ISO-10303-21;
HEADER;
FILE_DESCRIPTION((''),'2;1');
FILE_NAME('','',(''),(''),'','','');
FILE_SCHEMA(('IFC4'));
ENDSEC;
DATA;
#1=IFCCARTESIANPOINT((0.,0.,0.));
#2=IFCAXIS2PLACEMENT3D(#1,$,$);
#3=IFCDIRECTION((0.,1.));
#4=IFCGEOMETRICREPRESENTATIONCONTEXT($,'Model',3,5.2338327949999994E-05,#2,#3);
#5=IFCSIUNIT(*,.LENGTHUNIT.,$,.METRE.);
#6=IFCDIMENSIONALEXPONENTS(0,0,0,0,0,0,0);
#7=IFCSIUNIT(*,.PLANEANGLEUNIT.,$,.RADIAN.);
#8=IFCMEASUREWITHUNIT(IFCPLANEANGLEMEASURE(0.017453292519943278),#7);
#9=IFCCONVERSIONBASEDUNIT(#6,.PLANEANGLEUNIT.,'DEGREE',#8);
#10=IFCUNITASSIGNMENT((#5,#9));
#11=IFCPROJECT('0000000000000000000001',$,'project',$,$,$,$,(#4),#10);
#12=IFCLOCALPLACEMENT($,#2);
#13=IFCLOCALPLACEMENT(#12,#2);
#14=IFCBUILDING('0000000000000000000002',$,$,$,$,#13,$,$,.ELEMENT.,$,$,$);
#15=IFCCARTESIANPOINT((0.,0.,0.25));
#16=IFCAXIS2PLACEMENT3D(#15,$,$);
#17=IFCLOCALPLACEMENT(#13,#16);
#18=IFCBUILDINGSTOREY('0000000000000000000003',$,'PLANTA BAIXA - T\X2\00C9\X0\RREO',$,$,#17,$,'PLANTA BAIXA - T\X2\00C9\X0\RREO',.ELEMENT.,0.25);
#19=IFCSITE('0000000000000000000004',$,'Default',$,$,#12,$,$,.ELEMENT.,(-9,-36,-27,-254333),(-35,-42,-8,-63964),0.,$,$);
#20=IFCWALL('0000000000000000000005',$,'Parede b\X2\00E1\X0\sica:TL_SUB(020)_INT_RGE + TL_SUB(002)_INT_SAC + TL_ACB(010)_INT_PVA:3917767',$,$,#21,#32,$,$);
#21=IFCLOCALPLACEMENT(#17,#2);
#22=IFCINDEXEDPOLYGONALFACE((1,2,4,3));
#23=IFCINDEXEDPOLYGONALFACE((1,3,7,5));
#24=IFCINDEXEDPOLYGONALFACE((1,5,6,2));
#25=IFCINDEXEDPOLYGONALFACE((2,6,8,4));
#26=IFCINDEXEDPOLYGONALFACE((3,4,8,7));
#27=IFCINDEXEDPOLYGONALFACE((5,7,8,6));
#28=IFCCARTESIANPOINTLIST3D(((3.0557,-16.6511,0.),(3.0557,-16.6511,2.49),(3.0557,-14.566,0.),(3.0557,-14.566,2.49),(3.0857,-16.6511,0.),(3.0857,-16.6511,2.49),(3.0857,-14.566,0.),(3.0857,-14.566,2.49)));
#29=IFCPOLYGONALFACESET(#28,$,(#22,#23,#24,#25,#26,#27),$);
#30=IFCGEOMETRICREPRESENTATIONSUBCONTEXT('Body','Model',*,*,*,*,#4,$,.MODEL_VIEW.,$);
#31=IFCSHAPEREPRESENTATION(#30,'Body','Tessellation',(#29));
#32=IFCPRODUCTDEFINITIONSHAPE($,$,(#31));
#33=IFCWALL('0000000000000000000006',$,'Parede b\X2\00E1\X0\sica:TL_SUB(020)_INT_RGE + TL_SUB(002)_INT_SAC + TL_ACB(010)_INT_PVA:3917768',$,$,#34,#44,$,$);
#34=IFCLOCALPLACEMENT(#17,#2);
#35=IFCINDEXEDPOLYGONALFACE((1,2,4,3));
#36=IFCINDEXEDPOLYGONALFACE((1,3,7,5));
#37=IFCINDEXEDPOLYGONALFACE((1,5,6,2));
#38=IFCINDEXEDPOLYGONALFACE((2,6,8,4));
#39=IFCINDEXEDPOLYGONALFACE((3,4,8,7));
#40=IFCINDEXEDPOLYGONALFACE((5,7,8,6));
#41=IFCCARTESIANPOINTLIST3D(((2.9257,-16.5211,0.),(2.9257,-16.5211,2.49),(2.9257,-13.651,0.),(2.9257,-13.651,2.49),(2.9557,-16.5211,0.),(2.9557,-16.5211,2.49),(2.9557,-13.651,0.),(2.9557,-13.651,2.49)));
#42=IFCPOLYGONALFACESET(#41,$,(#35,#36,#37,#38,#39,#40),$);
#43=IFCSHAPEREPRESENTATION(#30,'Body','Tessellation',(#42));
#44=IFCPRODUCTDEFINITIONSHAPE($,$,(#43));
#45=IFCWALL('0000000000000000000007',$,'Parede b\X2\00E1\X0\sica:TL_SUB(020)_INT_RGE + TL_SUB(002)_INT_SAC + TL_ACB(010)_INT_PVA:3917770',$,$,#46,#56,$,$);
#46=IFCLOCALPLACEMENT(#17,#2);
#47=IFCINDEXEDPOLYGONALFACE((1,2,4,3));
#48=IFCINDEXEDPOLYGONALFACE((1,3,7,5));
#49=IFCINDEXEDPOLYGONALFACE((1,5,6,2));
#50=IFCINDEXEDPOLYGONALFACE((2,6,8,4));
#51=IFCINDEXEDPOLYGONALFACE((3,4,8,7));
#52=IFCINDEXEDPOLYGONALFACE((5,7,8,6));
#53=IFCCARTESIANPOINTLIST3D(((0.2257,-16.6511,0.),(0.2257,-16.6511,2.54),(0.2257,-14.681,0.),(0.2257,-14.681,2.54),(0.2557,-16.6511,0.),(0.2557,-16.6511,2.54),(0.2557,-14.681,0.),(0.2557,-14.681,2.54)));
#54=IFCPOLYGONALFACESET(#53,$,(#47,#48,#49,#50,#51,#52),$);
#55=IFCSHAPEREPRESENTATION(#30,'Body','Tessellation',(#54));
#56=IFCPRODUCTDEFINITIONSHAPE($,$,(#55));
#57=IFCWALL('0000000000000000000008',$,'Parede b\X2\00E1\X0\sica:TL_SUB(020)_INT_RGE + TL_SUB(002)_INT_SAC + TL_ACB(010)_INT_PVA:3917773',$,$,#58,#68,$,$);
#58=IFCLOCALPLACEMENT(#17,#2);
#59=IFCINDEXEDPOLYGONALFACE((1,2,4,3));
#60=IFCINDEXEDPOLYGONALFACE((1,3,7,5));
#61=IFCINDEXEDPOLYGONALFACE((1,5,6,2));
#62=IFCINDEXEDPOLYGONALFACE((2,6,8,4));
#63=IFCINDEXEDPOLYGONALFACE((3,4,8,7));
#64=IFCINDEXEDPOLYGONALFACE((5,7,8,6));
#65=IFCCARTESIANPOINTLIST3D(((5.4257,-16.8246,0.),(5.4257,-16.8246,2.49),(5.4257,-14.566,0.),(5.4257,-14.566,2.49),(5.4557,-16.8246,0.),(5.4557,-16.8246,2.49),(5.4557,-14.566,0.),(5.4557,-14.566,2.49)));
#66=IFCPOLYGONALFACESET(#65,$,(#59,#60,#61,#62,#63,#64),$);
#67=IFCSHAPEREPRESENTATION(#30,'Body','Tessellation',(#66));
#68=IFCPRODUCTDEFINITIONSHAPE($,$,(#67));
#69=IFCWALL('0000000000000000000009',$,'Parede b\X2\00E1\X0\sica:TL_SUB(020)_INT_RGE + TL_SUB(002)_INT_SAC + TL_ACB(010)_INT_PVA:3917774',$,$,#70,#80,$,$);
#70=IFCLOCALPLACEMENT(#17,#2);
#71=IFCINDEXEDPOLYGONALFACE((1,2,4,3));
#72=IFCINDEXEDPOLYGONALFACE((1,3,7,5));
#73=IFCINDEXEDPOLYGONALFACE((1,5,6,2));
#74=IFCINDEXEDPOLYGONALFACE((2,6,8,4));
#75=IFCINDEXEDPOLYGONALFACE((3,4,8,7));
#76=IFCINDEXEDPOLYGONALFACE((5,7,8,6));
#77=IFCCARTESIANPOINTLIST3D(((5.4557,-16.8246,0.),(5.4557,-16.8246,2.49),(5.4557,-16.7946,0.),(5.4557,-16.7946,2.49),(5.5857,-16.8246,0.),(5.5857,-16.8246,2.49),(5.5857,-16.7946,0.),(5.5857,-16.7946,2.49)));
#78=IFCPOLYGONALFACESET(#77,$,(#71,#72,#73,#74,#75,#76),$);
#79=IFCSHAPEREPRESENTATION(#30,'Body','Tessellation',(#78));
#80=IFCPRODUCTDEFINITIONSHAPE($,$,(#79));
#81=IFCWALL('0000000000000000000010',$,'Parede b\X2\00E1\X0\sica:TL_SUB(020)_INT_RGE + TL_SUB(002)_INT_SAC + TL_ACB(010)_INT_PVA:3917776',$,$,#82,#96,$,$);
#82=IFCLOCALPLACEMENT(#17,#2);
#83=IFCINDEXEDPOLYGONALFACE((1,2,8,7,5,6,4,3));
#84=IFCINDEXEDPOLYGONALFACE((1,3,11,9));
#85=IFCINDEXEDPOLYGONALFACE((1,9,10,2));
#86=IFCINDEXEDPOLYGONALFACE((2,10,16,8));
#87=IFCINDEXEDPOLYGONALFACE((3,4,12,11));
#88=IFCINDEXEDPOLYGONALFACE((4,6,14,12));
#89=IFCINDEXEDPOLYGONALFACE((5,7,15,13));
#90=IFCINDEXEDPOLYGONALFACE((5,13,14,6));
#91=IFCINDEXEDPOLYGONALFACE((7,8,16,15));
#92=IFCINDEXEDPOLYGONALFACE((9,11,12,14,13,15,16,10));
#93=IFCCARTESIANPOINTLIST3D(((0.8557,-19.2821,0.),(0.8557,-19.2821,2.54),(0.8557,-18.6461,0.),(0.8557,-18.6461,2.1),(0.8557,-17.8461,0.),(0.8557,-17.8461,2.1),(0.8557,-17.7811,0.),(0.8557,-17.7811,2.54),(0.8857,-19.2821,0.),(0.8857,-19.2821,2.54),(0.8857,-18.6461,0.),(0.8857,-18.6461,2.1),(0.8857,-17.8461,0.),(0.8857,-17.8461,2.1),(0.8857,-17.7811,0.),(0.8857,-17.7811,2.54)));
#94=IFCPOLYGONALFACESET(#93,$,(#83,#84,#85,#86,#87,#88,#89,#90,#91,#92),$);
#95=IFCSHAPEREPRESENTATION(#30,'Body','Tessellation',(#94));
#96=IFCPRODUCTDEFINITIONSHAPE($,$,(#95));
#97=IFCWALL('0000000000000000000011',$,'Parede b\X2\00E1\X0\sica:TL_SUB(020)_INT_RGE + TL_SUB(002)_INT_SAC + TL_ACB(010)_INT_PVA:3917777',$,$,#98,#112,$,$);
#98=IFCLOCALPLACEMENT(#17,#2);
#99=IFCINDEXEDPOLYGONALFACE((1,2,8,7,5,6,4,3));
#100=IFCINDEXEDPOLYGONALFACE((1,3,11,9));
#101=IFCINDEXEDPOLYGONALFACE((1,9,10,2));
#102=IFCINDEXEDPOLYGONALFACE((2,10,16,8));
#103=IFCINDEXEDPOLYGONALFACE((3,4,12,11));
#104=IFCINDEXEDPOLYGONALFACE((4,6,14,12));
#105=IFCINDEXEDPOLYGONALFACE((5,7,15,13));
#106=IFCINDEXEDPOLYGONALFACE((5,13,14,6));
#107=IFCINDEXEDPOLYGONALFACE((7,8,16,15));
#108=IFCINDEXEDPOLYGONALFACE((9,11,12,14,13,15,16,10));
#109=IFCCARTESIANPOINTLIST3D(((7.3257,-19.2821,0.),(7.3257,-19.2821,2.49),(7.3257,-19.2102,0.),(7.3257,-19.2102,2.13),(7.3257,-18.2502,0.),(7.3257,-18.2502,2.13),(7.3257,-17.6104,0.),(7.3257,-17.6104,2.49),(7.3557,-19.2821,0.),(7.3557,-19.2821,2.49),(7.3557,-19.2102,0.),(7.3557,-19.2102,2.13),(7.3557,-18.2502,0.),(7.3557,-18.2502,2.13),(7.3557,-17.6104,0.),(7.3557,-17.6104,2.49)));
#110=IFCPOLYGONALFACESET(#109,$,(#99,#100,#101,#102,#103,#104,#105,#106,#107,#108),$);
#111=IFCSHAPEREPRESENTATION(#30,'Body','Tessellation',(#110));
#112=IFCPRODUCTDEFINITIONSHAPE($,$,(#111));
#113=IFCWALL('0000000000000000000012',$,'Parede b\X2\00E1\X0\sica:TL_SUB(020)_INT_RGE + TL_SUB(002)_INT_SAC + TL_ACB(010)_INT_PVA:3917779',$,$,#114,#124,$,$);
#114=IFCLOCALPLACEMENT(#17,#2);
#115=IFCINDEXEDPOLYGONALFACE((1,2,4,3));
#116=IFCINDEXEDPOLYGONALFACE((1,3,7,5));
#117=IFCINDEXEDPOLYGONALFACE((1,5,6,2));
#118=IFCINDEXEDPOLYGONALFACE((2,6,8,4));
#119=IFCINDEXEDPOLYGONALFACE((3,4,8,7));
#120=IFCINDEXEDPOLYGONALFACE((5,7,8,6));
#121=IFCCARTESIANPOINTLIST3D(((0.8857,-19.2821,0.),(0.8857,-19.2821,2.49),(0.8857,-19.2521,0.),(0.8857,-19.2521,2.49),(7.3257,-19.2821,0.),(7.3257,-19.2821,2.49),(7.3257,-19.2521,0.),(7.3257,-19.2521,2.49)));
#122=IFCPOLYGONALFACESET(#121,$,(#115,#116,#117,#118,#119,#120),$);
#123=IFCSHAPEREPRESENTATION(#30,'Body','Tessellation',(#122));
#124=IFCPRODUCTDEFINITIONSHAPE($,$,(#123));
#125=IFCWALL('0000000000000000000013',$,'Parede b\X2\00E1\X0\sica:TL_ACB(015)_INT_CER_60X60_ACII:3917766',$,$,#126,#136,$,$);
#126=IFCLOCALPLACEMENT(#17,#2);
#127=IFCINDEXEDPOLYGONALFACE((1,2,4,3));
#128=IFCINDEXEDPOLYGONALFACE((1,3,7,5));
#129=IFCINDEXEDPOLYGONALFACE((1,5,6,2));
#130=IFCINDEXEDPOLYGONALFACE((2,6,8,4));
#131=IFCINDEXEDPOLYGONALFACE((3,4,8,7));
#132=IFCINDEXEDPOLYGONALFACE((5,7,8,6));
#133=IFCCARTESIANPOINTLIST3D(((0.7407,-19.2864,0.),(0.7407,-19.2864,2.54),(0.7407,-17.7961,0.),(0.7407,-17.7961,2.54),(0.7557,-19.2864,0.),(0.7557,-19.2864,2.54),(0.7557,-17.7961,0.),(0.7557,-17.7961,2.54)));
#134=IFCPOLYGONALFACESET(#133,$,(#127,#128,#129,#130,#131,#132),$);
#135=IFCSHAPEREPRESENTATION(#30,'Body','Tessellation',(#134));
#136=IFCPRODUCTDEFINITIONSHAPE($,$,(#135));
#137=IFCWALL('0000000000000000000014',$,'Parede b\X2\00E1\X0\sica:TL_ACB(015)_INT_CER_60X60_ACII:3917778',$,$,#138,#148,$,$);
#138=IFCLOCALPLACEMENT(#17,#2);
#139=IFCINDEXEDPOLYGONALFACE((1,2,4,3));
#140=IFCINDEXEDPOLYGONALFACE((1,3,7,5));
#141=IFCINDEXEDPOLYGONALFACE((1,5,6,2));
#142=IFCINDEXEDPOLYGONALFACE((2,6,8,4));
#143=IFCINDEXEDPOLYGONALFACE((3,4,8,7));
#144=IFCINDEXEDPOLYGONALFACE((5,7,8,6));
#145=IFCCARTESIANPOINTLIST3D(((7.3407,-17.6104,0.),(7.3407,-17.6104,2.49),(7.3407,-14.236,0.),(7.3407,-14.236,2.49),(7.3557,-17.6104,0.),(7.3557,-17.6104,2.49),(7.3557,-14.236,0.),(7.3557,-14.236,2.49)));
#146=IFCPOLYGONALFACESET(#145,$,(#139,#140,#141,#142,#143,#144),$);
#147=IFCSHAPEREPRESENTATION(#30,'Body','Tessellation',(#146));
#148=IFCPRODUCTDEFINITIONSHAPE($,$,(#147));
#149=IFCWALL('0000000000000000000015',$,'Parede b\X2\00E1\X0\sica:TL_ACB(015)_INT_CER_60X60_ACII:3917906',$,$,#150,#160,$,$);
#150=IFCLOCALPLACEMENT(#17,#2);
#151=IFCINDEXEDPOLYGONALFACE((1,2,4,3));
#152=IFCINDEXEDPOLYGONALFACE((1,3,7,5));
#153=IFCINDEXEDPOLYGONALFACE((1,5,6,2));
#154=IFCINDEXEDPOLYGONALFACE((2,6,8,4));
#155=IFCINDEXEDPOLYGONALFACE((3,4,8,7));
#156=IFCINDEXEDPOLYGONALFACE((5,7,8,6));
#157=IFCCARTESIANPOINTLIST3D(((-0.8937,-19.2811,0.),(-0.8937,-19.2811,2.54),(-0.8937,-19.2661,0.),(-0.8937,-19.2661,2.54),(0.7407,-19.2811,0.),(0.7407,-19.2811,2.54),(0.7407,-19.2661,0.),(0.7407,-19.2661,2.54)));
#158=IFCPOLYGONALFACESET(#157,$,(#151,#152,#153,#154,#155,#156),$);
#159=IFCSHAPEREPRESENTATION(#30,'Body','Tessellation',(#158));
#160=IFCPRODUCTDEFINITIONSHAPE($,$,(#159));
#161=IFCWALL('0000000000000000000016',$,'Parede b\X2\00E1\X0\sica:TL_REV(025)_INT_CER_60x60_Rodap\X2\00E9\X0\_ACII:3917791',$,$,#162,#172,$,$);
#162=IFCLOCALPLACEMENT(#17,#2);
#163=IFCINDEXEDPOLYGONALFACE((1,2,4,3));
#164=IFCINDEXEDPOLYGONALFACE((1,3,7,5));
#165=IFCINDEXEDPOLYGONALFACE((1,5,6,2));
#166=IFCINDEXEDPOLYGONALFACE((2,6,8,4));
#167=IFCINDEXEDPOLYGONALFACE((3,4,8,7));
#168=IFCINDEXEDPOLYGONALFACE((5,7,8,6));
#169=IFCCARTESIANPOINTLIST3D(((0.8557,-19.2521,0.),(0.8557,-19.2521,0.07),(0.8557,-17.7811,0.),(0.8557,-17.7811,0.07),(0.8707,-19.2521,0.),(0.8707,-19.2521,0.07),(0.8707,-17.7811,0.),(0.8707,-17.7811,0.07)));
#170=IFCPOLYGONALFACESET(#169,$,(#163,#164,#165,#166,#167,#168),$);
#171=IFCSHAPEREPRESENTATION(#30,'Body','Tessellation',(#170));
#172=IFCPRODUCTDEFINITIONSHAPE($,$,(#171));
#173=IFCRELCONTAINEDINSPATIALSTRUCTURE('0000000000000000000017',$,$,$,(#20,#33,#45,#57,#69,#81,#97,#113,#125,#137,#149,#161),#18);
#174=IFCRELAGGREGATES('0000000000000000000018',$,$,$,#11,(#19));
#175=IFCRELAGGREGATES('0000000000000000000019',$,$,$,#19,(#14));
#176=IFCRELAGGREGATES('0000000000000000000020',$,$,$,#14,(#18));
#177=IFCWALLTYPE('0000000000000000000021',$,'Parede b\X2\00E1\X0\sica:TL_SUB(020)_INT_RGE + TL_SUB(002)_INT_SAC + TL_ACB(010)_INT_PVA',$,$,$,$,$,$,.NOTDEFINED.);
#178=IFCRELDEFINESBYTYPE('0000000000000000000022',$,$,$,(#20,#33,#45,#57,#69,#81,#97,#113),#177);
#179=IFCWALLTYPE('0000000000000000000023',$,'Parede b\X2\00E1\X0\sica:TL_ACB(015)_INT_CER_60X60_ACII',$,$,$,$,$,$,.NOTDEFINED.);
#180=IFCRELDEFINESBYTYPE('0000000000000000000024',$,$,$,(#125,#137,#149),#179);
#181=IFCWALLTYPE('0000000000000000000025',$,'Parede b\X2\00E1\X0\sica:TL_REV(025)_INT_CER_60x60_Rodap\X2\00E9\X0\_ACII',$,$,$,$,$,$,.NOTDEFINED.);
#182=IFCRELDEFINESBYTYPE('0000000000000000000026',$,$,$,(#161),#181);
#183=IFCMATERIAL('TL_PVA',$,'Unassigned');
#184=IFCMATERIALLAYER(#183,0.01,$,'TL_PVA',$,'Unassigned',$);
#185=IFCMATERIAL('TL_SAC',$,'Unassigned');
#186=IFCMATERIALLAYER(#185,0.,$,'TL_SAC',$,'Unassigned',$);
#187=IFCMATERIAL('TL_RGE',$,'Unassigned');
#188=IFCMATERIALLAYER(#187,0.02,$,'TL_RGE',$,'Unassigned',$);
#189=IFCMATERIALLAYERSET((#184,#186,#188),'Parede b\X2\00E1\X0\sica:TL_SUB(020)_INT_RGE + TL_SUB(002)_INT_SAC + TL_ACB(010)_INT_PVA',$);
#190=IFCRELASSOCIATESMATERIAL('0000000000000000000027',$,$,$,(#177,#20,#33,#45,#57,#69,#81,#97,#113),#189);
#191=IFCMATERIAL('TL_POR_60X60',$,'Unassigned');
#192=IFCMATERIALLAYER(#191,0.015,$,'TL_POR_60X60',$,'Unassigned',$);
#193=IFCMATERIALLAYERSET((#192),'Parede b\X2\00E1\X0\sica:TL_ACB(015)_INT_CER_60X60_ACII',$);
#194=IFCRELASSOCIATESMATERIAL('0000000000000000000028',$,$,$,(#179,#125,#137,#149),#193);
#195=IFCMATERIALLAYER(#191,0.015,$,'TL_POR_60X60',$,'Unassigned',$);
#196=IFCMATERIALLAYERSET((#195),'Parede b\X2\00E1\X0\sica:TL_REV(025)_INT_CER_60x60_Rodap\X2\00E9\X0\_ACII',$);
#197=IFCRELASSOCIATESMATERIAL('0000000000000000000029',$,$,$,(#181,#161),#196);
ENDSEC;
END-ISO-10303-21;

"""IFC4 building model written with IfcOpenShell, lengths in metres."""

from ifc_helpers import new_model, entity, si_unit, converted_unit, direction, frame, frame_2d, origin, place, context, subcontext, project, spatial, rectangle, extrude, material, layer, layer_set, layer_usage, type_object, element, save


model = new_model("IFC4")

# Units and contexts
model_context = context("Model", 3, precision=5.2338327949999994e-05, world=origin(), true_north=direction((0.0, 1.0)))
body_context = subcontext(model_context, "Body", "Model", "MODEL_VIEW")
ifc_project = project(units=[si_unit("LENGTHUNIT", "METRE"), converted_unit("PLANEANGLEUNIT", "DEGREE", entity("IfcPlaneAngleMeasure", 0.017453292519943278), si_unit("PLANEANGLEUNIT", "RADIAN"), dimensions=[0, 0, 0, 0, 0, 0, 0])], contexts=[model_context])

# Site, building, storey
site_placement = place(None, frame((0.0, 0.0, 0.0)))
site = spatial("IfcSite", under=ifc_project, at=site_placement, Name="Default", CompositionType="ELEMENT", RefLatitude=(-9, -36, -27, -254333), RefLongitude=(-35, -42, -8, -63964), RefElevation=0.0)
building_placement = place(site_placement, origin())
building = spatial("IfcBuilding", under=site, at=building_placement, CompositionType="ELEMENT")
storey_placement = place(building_placement, frame((0.0, 0.0, 0.25)))
storey = spatial("IfcBuildingStorey", under=building, at=storey_placement, Name="PLANTA BAIXA - TÉRREO", LongName="PLANTA BAIXA - TÉRREO", CompositionType="ELEMENT", Elevation=0.25)

# Shared definitions
ifc_material_1 = material(Name="TL_PVA", Category="Unassigned")
ifc_layer_1 = layer(ifc_material_1, 0.01, Name="TL_PVA", Category="Unassigned")
ifc_material_2 = material(Name="TL_SAC", Category="Unassigned")
ifc_layer_2 = layer(ifc_material_2, 0.0, Name="TL_SAC", Category="Unassigned")
ifc_material_3 = material(Name="TL_RGE", Category="Unassigned")
ifc_layer_3 = layer(ifc_material_3, 0.02, Name="TL_RGE", Category="Unassigned")
ifc_layer_set_1 = layer_set([ifc_layer_1, ifc_layer_2, ifc_layer_3], Name="Parede básica:TL_SUB(020)_INT_RGE + TL_SUB(002)_INT_SAC + TL_ACB(010)_INT_PVA")
wall_type_1 = type_object("IfcWallType", Name="Parede básica:TL_SUB(020)_INT_RGE + TL_SUB(002)_INT_SAC + TL_ACB(010)_INT_PVA", PredefinedType="NOTDEFINED", material=ifc_layer_set_1)

# Walls
ifc_layer_usage_1 = layer_usage(ifc_layer_set_1, "AXIS2", "NEGATIVE", 0.015)
wall_1_placement = place(storey_placement, frame((3.0707, -14.566, 0.0), z_axis=(0.0, 0.0, 1.0), x_axis=(0.0, -1.0, 0.0)))
element("IfcWall", 1, at=wall_1_placement, inside=storey, type_object=wall_type_1, material=ifc_layer_usage_1, Name="Parede básica:TL_SUB(020)_INT_RGE + TL_SUB(002)_INT_SAC + TL_ACB(010)_INT_PVA:3917767", context=body_context, shape_type="SweptSolid", body=[
    extrude(rectangle(XDim=2.0851, YDim=0.03, at=frame_2d((1.0426, 0.0), x_axis=(-1.0, 0.0))), origin(), (0.0, 0.0, 1.0), 2.49),
])
ifc_layer_usage_2 = layer_usage(ifc_layer_set_1, "AXIS2", "NEGATIVE", 0.015)
wall_2_placement = place(storey_placement, frame((2.9407, -16.5211, 0.0), z_axis=(0.0, 0.0, 1.0), x_axis=(0.0, 1.0, 0.0)))
element("IfcWall", 2, at=wall_2_placement, inside=storey, type_object=wall_type_1, material=ifc_layer_usage_2, Name="Parede básica:TL_SUB(020)_INT_RGE + TL_SUB(002)_INT_SAC + TL_ACB(010)_INT_PVA:3917768", context=body_context, shape_type="SweptSolid", body=[
    extrude(rectangle(XDim=2.8701, YDim=0.03, at=frame_2d((1.4351, 0.0), x_axis=(-1.0, 0.0))), origin(), (0.0, 0.0, 1.0), 2.49),
])
ifc_layer_usage_3 = layer_usage(ifc_layer_set_1, "AXIS2", "NEGATIVE", 0.015)
wall_3_placement = place(storey_placement, frame((0.2407, -16.6511, 0.0), z_axis=(0.0, 0.0, 1.0), x_axis=(0.0, 1.0, 0.0)))
element("IfcWall", 3, at=wall_3_placement, inside=storey, type_object=wall_type_1, material=ifc_layer_usage_3, Name="Parede básica:TL_SUB(020)_INT_RGE + TL_SUB(002)_INT_SAC + TL_ACB(010)_INT_PVA:3917770", context=body_context, shape_type="SweptSolid", body=[
    extrude(rectangle(XDim=1.9701, YDim=0.03, at=frame_2d((0.9851, 0.0), x_axis=(-1.0, 0.0))), origin(), (0.0, 0.0, 1.0), 2.54),
])
ifc_layer_usage_4 = layer_usage(ifc_layer_set_1, "AXIS2", "NEGATIVE", 0.015)
wall_4_placement = place(storey_placement, frame((5.4407, -16.8246, 0.0), z_axis=(0.0, 0.0, 1.0), x_axis=(0.0, 1.0, 0.0)))
element("IfcWall", 4, at=wall_4_placement, inside=storey, type_object=wall_type_1, material=ifc_layer_usage_4, Name="Parede básica:TL_SUB(020)_INT_RGE + TL_SUB(002)_INT_SAC + TL_ACB(010)_INT_PVA:3917773", context=body_context, shape_type="SweptSolid", body=[
    extrude(rectangle(XDim=2.2587, YDim=0.03, at=frame_2d((1.1293, 0.0), x_axis=(-1.0, 0.0))), origin(), (0.0, 0.0, 1.0), 2.49),
])
ifc_layer_usage_5 = layer_usage(ifc_layer_set_1, "AXIS2", "NEGATIVE", 0.015)
wall_5_placement = place(storey_placement, frame((5.5857, -16.8096, 0.0), z_axis=(0.0, 0.0, 1.0), x_axis=(-1.0, 0.0, 0.0)))
element("IfcWall", 5, at=wall_5_placement, inside=storey, type_object=wall_type_1, material=ifc_layer_usage_5, Name="Parede básica:TL_SUB(020)_INT_RGE + TL_SUB(002)_INT_SAC + TL_ACB(010)_INT_PVA:3917774", context=body_context, shape_type="SweptSolid", body=[
    extrude(rectangle(XDim=0.13, YDim=0.03, at=frame_2d((0.065, 0.0), x_axis=(-1.0, 0.0))), origin(), (0.0, 0.0, 1.0), 2.49),
])

# Walls, openings
ifc_layer_usage_6 = layer_usage(ifc_layer_set_1, "AXIS2", "NEGATIVE", 0.015)
wall_6_placement = place(storey_placement, frame((0.8707, -17.7811, 0.0), z_axis=(0.0, 0.0, 1.0), x_axis=(0.0, -1.0, 0.0)))
wall_6 = element("IfcWall", 6, at=wall_6_placement, inside=storey, type_object=wall_type_1, material=ifc_layer_usage_6, Name="Parede básica:TL_SUB(020)_INT_RGE + TL_SUB(002)_INT_SAC + TL_ACB(010)_INT_PVA:3917776", context=body_context, shape_type="SweptSolid", body=[
    extrude(rectangle(XDim=1.501, YDim=0.03, at=frame_2d((0.7505, 0.0), x_axis=(-1.0, 0.0))), origin(), (0.0, 0.0, 1.0), 2.54),
])
opening_1_placement = place(wall_6_placement, frame((0.865, 0.015, 0.0)))
element("IfcOpeningElement", 7, at=opening_1_placement, cuts=wall_6, PredefinedType="OPENING", context=body_context, shape_type="SweptSolid", body=[
    extrude(rectangle(XDim=2.1, YDim=0.8, at=frame_2d((1.05, 0.4), x_axis=(1.0, 0.0))), frame((0.0, 0.0, 0.0), z_axis=(0.0, -1.0, 0.0), x_axis=(0.0, 0.0, 1.0)), (0.0, 0.0, 1.0), 0.03),
])
ifc_layer_usage_7 = layer_usage(ifc_layer_set_1, "AXIS2", "NEGATIVE", 0.015)
wall_7_placement = place(storey_placement, frame((7.3407, -19.2821, 0.0), z_axis=(0.0, 0.0, 1.0), x_axis=(0.0, 1.0, 0.0)))
wall_7 = element("IfcWall", 8, at=wall_7_placement, inside=storey, type_object=wall_type_1, material=ifc_layer_usage_7, Name="Parede básica:TL_SUB(020)_INT_RGE + TL_SUB(002)_INT_SAC + TL_ACB(010)_INT_PVA:3917777", context=body_context, shape_type="SweptSolid", body=[
    extrude(rectangle(XDim=1.6717, YDim=0.03, at=frame_2d((0.8359, 0.0), x_axis=(1.0, 0.0))), origin(), (0.0, 0.0, 1.0), 2.49),
])
opening_2_placement = place(wall_7_placement, frame((19.2821, 7.3407, 0.0)))
element("IfcOpeningElement", 9, at=opening_2_placement, cuts=wall_7, PredefinedType="OPENING", context=body_context, shape_type="SweptSolid", body=[
    extrude(rectangle(XDim=2.13, YDim=0.96, at=frame_2d((0.0, 0.0), x_axis=(0.0, 1.0))), frame((-18.7302, -8.8797, 1.065), z_axis=(0.0, 1.0, 0.0), x_axis=(-1.0, 0.0, 0.0)), (0.0, 0.0, 1.0), 3.048),
])

# Walls
ifc_layer_usage_8 = layer_usage(ifc_layer_set_1, "AXIS2", "POSITIVE", -0.015)
wall_8_placement = place(storey_placement, frame((7.3257, -19.2671, 0.0), z_axis=(0.0, 0.0, 1.0), x_axis=(-1.0, 0.0, 0.0)))
element("IfcWall", 10, at=wall_8_placement, inside=storey, type_object=wall_type_1, material=ifc_layer_usage_8, Name="Parede básica:TL_SUB(020)_INT_RGE + TL_SUB(002)_INT_SAC + TL_ACB(010)_INT_PVA:3917779", context=body_context, shape_type="SweptSolid", body=[
    extrude(rectangle(XDim=6.44, YDim=0.03, at=frame_2d((3.22, 0.0), x_axis=(-1.0, 0.0))), origin(), (0.0, 0.0, 1.0), 2.49),
])
ifc_material_4 = material(Name="TL_POR_60X60", Category="Unassigned")
ifc_layer_4 = layer(ifc_material_4, 0.015, Name="TL_POR_60X60", Category="Unassigned")
ifc_layer_set_2 = layer_set([ifc_layer_4], Name="Parede básica:TL_ACB(015)_INT_CER_60X60_ACII")
ifc_layer_usage_9 = layer_usage(ifc_layer_set_2, "AXIS2", "NEGATIVE", 0.0075)
wall_type_2 = type_object("IfcWallType", Name="Parede básica:TL_ACB(015)_INT_CER_60X60_ACII", PredefinedType="NOTDEFINED", material=ifc_layer_set_2)
wall_9_placement = place(storey_placement, frame((0.7482, -19.2864, 0.0), z_axis=(0.0, 0.0, 1.0), x_axis=(0.0, 1.0, 0.0)))
element("IfcWall", 11, at=wall_9_placement, inside=storey, type_object=wall_type_2, material=ifc_layer_usage_9, Name="Parede básica:TL_ACB(015)_INT_CER_60X60_ACII:3917766", context=body_context, shape_type="SweptSolid", body=[
    extrude(rectangle(XDim=1.4902, YDim=0.015, at=frame_2d((0.7451, 0.0), x_axis=(-1.0, 0.0))), origin(), (0.0, 0.0, 1.0), 2.54),
])
ifc_layer_usage_10 = layer_usage(ifc_layer_set_2, "AXIS2", "NEGATIVE", 0.0075)
wall_10_placement = place(storey_placement, frame((7.3482, -17.6104, 0.0), z_axis=(0.0, 0.0, 1.0), x_axis=(0.0, 1.0, 0.0)))
element("IfcWall", 12, at=wall_10_placement, inside=storey, type_object=wall_type_2, material=ifc_layer_usage_10, Name="Parede básica:TL_ACB(015)_INT_CER_60X60_ACII:3917778", context=body_context, shape_type="SweptSolid", body=[
    extrude(rectangle(XDim=3.3744, YDim=0.015, at=frame_2d((1.6872, 0.0), x_axis=(-1.0, 0.0))), origin(), (0.0, 0.0, 1.0), 2.49),
])
ifc_layer_usage_11 = layer_usage(ifc_layer_set_2, "AXIS2", "POSITIVE", -0.0075)
wall_11_placement = place(storey_placement, frame((0.7407, -19.2736, 0.0), z_axis=(0.0, 0.0, 1.0), x_axis=(-1.0, 0.0, 0.0)))
element("IfcWall", 13, at=wall_11_placement, inside=storey, type_object=wall_type_2, material=ifc_layer_usage_11, Name="Parede básica:TL_ACB(015)_INT_CER_60X60_ACII:3917906", context=body_context, shape_type="SweptSolid", body=[
    extrude(rectangle(XDim=1.6345, YDim=0.015, at=frame_2d((0.8172, 0.0), x_axis=(-1.0, 0.0))), origin(), (0.0, 0.0, 1.0), 2.54),
])
ifc_layer_5 = layer(ifc_material_4, 0.015, Name="TL_POR_60X60", Category="Unassigned")
ifc_layer_set_3 = layer_set([ifc_layer_5], Name="Parede básica:TL_REV(025)_INT_CER_60x60_Rodapé_ACII")
ifc_layer_usage_12 = layer_usage(ifc_layer_set_3, "AXIS2", "POSITIVE", -0.0075)
wall_type_3 = type_object("IfcWallType", Name="Parede básica:TL_REV(025)_INT_CER_60x60_Rodapé_ACII", PredefinedType="NOTDEFINED", material=ifc_layer_set_3)
wall_12_placement = place(storey_placement, frame((0.8632, -19.2521, 0.0), z_axis=(0.0, 0.0, 1.0), x_axis=(0.0, 1.0, 0.0)))
element("IfcWall", 14, at=wall_12_placement, inside=storey, type_object=wall_type_3, material=ifc_layer_usage_12, Name="Parede básica:TL_REV(025)_INT_CER_60x60_Rodapé_ACII:3917791", context=body_context, shape_type="SweptSolid", body=[
    extrude(rectangle(XDim=1.471, YDim=0.015, at=frame_2d((0.7355, 0.0), x_axis=(-1.0, 0.0))), origin(), (0.0, 0.0, 1.0), 0.07),
])

save(model, "model.ifc")
